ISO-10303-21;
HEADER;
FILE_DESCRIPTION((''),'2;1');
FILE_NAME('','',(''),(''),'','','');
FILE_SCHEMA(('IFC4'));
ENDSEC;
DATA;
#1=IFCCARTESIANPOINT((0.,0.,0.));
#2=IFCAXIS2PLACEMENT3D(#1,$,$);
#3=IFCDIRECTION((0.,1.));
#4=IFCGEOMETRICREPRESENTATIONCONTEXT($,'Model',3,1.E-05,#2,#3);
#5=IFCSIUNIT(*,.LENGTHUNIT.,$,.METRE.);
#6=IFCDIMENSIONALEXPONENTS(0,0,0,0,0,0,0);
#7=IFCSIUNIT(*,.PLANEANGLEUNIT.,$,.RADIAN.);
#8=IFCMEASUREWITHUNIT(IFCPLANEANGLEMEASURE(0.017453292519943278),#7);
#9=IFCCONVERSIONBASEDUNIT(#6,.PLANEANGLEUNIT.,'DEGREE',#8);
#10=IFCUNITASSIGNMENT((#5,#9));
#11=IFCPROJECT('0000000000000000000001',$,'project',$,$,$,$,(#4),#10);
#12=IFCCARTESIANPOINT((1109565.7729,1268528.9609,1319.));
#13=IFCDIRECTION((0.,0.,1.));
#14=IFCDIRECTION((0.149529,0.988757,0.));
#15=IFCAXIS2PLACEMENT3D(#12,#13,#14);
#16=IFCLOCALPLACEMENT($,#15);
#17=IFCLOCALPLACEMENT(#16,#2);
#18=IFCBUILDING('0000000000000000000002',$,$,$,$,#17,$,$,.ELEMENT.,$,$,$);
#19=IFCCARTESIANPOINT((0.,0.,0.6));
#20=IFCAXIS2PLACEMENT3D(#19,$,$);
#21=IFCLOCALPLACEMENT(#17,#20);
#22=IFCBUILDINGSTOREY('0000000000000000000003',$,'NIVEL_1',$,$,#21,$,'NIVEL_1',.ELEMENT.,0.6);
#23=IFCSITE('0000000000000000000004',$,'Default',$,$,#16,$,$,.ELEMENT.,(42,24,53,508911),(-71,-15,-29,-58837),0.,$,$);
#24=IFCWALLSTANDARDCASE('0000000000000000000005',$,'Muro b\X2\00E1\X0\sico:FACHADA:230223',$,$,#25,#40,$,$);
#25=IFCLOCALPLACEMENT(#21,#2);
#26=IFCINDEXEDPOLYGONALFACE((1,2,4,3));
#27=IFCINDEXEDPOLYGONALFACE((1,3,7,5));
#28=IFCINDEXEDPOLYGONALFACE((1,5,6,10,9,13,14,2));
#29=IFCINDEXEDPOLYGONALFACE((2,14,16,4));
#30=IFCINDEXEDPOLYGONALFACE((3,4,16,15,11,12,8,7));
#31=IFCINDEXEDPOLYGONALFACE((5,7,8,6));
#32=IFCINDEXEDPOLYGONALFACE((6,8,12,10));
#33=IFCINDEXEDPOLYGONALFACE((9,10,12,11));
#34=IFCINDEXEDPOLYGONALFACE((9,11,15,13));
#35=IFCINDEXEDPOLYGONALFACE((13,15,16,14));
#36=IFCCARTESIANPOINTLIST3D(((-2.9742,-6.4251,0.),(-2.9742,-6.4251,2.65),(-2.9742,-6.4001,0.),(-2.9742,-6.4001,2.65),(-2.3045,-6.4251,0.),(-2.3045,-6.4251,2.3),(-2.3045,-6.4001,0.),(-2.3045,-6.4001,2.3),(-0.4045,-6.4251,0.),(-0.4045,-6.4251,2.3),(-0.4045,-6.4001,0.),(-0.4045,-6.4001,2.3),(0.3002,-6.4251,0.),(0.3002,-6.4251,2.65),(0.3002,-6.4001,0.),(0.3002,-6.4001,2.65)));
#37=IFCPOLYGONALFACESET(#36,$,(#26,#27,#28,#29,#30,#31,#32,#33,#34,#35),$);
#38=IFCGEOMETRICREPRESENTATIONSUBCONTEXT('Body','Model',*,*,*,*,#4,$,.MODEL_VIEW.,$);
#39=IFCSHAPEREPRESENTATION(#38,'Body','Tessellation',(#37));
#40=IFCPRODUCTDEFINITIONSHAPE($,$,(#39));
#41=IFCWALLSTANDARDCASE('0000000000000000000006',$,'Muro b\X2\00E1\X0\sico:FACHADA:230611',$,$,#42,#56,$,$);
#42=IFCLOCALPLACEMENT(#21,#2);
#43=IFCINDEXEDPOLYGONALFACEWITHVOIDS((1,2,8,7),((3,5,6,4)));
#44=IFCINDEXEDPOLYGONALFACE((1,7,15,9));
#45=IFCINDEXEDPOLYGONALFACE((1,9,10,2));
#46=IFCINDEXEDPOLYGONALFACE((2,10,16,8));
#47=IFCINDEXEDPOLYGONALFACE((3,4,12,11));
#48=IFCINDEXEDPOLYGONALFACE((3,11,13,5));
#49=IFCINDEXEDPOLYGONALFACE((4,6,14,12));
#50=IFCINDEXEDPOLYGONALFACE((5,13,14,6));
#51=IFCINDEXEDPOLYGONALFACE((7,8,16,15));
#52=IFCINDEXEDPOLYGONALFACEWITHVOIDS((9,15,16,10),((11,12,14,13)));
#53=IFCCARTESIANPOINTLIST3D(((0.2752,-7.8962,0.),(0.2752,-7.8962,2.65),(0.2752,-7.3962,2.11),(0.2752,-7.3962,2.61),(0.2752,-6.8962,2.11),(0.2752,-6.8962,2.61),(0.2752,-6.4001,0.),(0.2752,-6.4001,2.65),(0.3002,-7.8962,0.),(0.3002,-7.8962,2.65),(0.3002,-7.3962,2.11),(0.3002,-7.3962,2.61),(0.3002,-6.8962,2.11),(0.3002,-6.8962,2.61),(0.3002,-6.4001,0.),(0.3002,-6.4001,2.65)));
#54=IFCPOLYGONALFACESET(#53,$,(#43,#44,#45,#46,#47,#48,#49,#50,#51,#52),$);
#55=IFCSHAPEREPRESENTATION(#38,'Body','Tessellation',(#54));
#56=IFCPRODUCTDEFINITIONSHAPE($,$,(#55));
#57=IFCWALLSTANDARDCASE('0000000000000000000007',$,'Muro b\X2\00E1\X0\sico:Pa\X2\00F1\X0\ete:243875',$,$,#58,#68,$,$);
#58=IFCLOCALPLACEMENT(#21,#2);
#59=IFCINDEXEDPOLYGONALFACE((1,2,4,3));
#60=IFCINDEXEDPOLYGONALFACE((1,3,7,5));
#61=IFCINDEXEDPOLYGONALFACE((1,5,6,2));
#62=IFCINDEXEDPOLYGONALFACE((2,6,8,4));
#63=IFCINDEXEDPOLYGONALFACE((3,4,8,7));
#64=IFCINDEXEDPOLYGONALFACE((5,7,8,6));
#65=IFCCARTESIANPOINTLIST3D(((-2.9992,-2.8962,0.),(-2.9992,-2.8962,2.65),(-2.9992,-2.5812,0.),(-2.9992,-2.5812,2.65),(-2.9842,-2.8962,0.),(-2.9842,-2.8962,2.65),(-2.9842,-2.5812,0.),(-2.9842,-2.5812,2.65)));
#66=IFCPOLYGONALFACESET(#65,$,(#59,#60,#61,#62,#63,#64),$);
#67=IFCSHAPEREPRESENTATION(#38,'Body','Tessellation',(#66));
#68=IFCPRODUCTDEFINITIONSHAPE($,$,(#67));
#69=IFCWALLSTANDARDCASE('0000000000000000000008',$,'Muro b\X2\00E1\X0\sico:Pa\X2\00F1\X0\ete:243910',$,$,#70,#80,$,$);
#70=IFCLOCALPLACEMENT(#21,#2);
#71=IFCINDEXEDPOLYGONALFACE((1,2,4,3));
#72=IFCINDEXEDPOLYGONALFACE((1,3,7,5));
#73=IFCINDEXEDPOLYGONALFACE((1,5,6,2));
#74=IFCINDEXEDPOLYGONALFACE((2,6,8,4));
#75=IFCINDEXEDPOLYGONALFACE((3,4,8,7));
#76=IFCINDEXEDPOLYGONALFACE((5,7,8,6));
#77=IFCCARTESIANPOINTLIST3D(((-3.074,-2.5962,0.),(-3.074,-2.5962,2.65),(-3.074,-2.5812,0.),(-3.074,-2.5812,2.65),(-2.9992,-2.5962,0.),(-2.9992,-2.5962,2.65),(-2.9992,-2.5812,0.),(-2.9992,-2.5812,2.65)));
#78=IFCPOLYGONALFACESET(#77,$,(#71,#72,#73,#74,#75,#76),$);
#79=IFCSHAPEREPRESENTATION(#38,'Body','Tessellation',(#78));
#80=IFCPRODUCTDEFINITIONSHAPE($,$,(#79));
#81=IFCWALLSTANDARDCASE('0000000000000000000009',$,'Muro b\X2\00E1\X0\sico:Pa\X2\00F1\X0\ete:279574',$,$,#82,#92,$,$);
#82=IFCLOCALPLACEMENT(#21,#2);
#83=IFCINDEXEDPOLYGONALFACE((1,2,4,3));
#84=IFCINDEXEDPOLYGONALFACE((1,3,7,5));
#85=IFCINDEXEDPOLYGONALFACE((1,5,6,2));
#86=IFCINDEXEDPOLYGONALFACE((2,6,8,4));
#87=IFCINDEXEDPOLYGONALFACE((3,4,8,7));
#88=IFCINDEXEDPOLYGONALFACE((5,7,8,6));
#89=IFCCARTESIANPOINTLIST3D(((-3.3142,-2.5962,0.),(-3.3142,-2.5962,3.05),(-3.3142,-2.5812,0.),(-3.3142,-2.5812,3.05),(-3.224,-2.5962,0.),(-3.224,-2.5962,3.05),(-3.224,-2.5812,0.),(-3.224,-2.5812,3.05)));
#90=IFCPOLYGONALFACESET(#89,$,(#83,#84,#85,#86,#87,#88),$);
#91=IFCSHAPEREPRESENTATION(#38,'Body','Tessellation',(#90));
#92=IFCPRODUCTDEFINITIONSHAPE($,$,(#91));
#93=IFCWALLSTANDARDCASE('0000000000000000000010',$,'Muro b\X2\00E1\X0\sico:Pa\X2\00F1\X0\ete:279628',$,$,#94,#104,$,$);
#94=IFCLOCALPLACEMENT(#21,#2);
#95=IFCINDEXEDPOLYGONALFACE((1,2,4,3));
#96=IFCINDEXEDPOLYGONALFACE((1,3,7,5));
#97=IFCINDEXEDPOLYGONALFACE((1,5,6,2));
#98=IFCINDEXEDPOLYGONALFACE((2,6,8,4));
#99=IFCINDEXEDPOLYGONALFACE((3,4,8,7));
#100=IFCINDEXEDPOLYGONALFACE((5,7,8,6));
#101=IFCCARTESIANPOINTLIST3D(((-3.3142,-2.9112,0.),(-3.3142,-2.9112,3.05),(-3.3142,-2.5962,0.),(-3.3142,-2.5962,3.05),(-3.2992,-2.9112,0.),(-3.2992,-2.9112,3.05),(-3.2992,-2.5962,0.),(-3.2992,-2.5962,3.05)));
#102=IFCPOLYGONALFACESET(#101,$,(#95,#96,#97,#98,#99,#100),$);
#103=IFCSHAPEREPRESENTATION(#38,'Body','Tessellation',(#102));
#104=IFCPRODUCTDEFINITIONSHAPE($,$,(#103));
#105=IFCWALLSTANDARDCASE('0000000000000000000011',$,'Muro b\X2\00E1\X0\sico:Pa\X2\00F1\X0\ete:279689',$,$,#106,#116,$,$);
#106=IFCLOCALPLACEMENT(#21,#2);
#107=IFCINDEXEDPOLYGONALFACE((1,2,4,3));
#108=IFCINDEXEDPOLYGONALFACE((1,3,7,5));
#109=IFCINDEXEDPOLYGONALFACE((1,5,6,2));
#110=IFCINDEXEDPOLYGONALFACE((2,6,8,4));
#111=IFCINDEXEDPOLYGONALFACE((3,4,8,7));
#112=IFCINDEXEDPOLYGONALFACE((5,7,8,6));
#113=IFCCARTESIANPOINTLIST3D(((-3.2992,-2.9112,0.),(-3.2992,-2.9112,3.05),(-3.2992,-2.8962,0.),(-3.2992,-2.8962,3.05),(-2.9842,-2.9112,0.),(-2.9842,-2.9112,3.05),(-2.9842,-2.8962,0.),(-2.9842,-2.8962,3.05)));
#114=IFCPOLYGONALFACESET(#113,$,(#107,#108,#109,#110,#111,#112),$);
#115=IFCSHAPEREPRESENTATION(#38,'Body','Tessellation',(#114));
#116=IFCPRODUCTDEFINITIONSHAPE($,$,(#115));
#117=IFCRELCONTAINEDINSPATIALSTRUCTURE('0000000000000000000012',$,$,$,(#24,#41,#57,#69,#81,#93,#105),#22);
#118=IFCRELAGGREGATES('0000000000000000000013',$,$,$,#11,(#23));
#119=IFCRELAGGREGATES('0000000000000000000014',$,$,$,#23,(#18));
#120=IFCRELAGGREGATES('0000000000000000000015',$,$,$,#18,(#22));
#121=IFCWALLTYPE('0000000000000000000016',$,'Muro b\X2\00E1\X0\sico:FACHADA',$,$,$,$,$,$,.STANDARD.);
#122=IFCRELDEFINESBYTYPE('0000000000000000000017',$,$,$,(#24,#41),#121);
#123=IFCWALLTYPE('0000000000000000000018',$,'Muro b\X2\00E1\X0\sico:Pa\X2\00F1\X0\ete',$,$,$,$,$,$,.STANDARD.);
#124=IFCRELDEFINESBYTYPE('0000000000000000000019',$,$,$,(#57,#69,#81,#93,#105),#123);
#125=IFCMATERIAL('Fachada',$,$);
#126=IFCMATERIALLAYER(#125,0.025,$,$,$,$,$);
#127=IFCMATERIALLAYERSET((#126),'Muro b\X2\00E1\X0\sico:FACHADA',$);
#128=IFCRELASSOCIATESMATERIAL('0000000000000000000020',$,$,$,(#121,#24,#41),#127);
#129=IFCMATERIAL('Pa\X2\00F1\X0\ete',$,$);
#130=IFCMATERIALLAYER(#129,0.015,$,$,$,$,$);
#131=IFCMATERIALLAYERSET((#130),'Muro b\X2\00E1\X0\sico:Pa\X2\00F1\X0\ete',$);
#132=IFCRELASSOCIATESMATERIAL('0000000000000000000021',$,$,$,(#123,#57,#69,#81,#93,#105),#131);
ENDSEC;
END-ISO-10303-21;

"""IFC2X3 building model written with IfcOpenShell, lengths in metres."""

from ifc_helpers import new_model, entity, si_unit, converted_unit, direction, frame, frame_2d, origin, place, context, subcontext, project, spatial, rectangle, extrude, material, layer, layer_set, layer_usage, type_object, element, save


model = new_model("IFC2X3")

# Units and contexts
model_context = context("Model", 3, precision=1e-05, world=origin(), true_north=direction((0.0, 1.0)))
body_context = subcontext(model_context, "Body", "Model", "MODEL_VIEW")
ifc_project = project(units=[si_unit("LENGTHUNIT", "METRE"), converted_unit("PLANEANGLEUNIT", "DEGREE", entity("IfcPlaneAngleMeasure", 0.017453292519943278), si_unit("PLANEANGLEUNIT", "RADIAN"), dimensions=[0, 0, 0, 0, 0, 0, 0])], contexts=[model_context])

# Site, building, storey
site_placement = place(None, frame((1109565.7729, 1268528.9609, 1319.0), z_axis=(0.0, 0.0, 1.0), x_axis=(0.149529, 0.988757, 0.0)))
site = spatial("IfcSite", under=ifc_project, at=site_placement, Name="Default", CompositionType="ELEMENT", RefLatitude=(42, 24, 53, 508911), RefLongitude=(-71, -15, -29, -58837), RefElevation=0.0)
building_placement = place(site_placement, origin())
building = spatial("IfcBuilding", under=site, at=building_placement, CompositionType="ELEMENT")
storey_placement = place(building_placement, frame((0.0, 0.0, 0.6)))
storey = spatial("IfcBuildingStorey", under=building, at=storey_placement, Name="NIVEL_1", LongName="NIVEL_1", CompositionType="ELEMENT", Elevation=0.6)

# Shared definitions
ifc_material_1 = material(Name="Pañete")

# Walls, openings
ifc_material_2 = material(Name="Fachada")
ifc_layer_1 = layer(ifc_material_2, 0.025)
ifc_layer_set_1 = layer_set([ifc_layer_1], Name="Muro básico:FACHADA")
ifc_layer_usage_1 = layer_usage(ifc_layer_set_1, "AXIS2", "POSITIVE", -0.0125)
wall_type_1 = type_object("IfcWallType", Name="Muro básico:FACHADA", PredefinedType="STANDARD", material=ifc_layer_set_1)
wall_1_placement = place(storey_placement, frame((-2.9742, -6.4126, 0.0)))
wall_1 = element("IfcWallStandardCase", 1, at=wall_1_placement, inside=storey, type_object=wall_type_1, material=ifc_layer_usage_1, Name="Muro básico:FACHADA:230223", context=body_context, shape_type="SweptSolid", body=[
    extrude(rectangle(XDim=3.2744, YDim=0.025, at=frame_2d((1.6372, 0.0), x_axis=(-1.0, 0.0))), origin(), (0.0, 0.0, 1.0), 2.65),
])
opening_1_placement = place(wall_1_placement, origin())
element("IfcOpeningElement", 2, at=opening_1_placement, cuts=wall_1, ObjectType="Opening", context=body_context, shape_type="SweptSolid", body=[
    extrude(rectangle(XDim=2.3, YDim=1.9, at=frame_2d((0.0, 0.0), x_axis=(0.0, 1.0))), frame((1.6197, 0.0125, 1.15), z_axis=(0.0, -1.0, 0.0), x_axis=(1.0, 0.0, 0.0)), (0.0, 0.0, 1.0), 0.025),
])
ifc_layer_usage_2 = layer_usage(ifc_layer_set_1, "AXIS2", "POSITIVE", -0.0125)
wall_2_placement = place(storey_placement, frame((0.2877, -6.4001, 0.0), z_axis=(0.0, 0.0, 1.0), x_axis=(0.0, -1.0, 0.0)))
wall_2 = element("IfcWallStandardCase", 3, at=wall_2_placement, inside=storey, type_object=wall_type_1, material=ifc_layer_usage_2, Name="Muro básico:FACHADA:230611", context=body_context, shape_type="SweptSolid", body=[
    extrude(rectangle(XDim=1.4961, YDim=0.025, at=frame_2d((0.748, 0.0), x_axis=(-1.0, 0.0))), origin(), (0.0, 0.0, 1.0), 2.65),
])
opening_2_placement = place(wall_2_placement, origin())
element("IfcOpeningElement", 4, at=opening_2_placement, cuts=wall_2, ObjectType="Opening", context=body_context, shape_type="SweptSolid", body=[
    extrude(rectangle(XDim=0.5, YDim=0.5, at=frame_2d((0.0, 0.0), x_axis=(0.0, 1.0))), frame((0.7461, 0.0125, 2.36), z_axis=(0.0, -1.0, 0.0), x_axis=(-1.0, 0.0, 0.0)), (0.0, 0.0, 1.0), 0.025),
])

# Walls
ifc_layer_2 = layer(ifc_material_1, 0.015)
ifc_layer_set_2 = layer_set([ifc_layer_2], Name="Muro básico:Pañete")
ifc_layer_usage_3 = layer_usage(ifc_layer_set_2, "AXIS2", "POSITIVE", -0.0075)
wall_type_2 = type_object("IfcWallType", Name="Muro básico:Pañete", PredefinedType="STANDARD", material=ifc_layer_set_2)
wall_3_placement = place(storey_placement, frame((-2.9917, -2.8962, 0.0), z_axis=(0.0, 0.0, 1.0), x_axis=(0.0, 1.0, 0.0)))
element("IfcWallStandardCase", 5, at=wall_3_placement, inside=storey, type_object=wall_type_2, material=ifc_layer_usage_3, Name="Muro básico:Pañete:243875", context=body_context, shape_type="SweptSolid", body=[
    extrude(rectangle(XDim=0.315, YDim=0.015, at=frame_2d((0.1575, 0.0), x_axis=(-1.0, 0.0))), origin(), (0.0, 0.0, 1.0), 2.65),
])
ifc_layer_usage_4 = layer_usage(ifc_layer_set_2, "AXIS2", "POSITIVE", -0.0075)
wall_4_placement = place(storey_placement, frame((-2.9992, -2.5887, 0.0), z_axis=(0.0, 0.0, 1.0), x_axis=(-1.0, 0.0, 0.0)))
element("IfcWallStandardCase", 6, at=wall_4_placement, inside=storey, type_object=wall_type_2, material=ifc_layer_usage_4, Name="Muro básico:Pañete:243910", context=body_context, shape_type="SweptSolid", body=[
    extrude(rectangle(XDim=0.0748, YDim=0.015, at=frame_2d((0.0374, 0.0), x_axis=(-1.0, 0.0))), origin(), (0.0, 0.0, 1.0), 2.65),
])
ifc_layer_usage_5 = layer_usage(ifc_layer_set_2, "AXIS2", "POSITIVE", -0.0075)
wall_5_placement = place(storey_placement, frame((-3.224, -2.5887, 0.0), z_axis=(0.0, 0.0, 1.0), x_axis=(-1.0, 0.0, 0.0)))
element("IfcWallStandardCase", 7, at=wall_5_placement, inside=storey, type_object=wall_type_2, material=ifc_layer_usage_5, Name="Muro básico:Pañete:279574", context=body_context, shape_type="SweptSolid", body=[
    extrude(rectangle(XDim=0.0902, YDim=0.015, at=frame_2d((0.0451, 0.0), x_axis=(-1.0, 0.0))), origin(), (0.0, 0.0, 1.0), 3.05),
])
ifc_layer_usage_6 = layer_usage(ifc_layer_set_2, "AXIS2", "POSITIVE", -0.0075)
wall_6_placement = place(storey_placement, frame((-3.3067, -2.5962, 0.0), z_axis=(0.0, 0.0, 1.0), x_axis=(0.0, -1.0, 0.0)))
element("IfcWallStandardCase", 8, at=wall_6_placement, inside=storey, type_object=wall_type_2, material=ifc_layer_usage_6, Name="Muro básico:Pañete:279628", context=body_context, shape_type="SweptSolid", body=[
    extrude(rectangle(XDim=0.315, YDim=0.015, at=frame_2d((0.1575, 0.0), x_axis=(-1.0, 0.0))), origin(), (0.0, 0.0, 1.0), 3.05),
])
ifc_layer_usage_7 = layer_usage(ifc_layer_set_2, "AXIS2", "POSITIVE", -0.0075)
wall_7_placement = place(storey_placement, frame((-3.2992, -2.9037, 0.0)))
element("IfcWallStandardCase", 9, at=wall_7_placement, inside=storey, type_object=wall_type_2, material=ifc_layer_usage_7, Name="Muro básico:Pañete:279689", context=body_context, shape_type="SweptSolid", body=[
    extrude(rectangle(XDim=0.315, YDim=0.015, at=frame_2d((0.1575, 0.0), x_axis=(-1.0, 0.0))), origin(), (0.0, 0.0, 1.0), 3.05),
])

save(model, "model.ifc")
